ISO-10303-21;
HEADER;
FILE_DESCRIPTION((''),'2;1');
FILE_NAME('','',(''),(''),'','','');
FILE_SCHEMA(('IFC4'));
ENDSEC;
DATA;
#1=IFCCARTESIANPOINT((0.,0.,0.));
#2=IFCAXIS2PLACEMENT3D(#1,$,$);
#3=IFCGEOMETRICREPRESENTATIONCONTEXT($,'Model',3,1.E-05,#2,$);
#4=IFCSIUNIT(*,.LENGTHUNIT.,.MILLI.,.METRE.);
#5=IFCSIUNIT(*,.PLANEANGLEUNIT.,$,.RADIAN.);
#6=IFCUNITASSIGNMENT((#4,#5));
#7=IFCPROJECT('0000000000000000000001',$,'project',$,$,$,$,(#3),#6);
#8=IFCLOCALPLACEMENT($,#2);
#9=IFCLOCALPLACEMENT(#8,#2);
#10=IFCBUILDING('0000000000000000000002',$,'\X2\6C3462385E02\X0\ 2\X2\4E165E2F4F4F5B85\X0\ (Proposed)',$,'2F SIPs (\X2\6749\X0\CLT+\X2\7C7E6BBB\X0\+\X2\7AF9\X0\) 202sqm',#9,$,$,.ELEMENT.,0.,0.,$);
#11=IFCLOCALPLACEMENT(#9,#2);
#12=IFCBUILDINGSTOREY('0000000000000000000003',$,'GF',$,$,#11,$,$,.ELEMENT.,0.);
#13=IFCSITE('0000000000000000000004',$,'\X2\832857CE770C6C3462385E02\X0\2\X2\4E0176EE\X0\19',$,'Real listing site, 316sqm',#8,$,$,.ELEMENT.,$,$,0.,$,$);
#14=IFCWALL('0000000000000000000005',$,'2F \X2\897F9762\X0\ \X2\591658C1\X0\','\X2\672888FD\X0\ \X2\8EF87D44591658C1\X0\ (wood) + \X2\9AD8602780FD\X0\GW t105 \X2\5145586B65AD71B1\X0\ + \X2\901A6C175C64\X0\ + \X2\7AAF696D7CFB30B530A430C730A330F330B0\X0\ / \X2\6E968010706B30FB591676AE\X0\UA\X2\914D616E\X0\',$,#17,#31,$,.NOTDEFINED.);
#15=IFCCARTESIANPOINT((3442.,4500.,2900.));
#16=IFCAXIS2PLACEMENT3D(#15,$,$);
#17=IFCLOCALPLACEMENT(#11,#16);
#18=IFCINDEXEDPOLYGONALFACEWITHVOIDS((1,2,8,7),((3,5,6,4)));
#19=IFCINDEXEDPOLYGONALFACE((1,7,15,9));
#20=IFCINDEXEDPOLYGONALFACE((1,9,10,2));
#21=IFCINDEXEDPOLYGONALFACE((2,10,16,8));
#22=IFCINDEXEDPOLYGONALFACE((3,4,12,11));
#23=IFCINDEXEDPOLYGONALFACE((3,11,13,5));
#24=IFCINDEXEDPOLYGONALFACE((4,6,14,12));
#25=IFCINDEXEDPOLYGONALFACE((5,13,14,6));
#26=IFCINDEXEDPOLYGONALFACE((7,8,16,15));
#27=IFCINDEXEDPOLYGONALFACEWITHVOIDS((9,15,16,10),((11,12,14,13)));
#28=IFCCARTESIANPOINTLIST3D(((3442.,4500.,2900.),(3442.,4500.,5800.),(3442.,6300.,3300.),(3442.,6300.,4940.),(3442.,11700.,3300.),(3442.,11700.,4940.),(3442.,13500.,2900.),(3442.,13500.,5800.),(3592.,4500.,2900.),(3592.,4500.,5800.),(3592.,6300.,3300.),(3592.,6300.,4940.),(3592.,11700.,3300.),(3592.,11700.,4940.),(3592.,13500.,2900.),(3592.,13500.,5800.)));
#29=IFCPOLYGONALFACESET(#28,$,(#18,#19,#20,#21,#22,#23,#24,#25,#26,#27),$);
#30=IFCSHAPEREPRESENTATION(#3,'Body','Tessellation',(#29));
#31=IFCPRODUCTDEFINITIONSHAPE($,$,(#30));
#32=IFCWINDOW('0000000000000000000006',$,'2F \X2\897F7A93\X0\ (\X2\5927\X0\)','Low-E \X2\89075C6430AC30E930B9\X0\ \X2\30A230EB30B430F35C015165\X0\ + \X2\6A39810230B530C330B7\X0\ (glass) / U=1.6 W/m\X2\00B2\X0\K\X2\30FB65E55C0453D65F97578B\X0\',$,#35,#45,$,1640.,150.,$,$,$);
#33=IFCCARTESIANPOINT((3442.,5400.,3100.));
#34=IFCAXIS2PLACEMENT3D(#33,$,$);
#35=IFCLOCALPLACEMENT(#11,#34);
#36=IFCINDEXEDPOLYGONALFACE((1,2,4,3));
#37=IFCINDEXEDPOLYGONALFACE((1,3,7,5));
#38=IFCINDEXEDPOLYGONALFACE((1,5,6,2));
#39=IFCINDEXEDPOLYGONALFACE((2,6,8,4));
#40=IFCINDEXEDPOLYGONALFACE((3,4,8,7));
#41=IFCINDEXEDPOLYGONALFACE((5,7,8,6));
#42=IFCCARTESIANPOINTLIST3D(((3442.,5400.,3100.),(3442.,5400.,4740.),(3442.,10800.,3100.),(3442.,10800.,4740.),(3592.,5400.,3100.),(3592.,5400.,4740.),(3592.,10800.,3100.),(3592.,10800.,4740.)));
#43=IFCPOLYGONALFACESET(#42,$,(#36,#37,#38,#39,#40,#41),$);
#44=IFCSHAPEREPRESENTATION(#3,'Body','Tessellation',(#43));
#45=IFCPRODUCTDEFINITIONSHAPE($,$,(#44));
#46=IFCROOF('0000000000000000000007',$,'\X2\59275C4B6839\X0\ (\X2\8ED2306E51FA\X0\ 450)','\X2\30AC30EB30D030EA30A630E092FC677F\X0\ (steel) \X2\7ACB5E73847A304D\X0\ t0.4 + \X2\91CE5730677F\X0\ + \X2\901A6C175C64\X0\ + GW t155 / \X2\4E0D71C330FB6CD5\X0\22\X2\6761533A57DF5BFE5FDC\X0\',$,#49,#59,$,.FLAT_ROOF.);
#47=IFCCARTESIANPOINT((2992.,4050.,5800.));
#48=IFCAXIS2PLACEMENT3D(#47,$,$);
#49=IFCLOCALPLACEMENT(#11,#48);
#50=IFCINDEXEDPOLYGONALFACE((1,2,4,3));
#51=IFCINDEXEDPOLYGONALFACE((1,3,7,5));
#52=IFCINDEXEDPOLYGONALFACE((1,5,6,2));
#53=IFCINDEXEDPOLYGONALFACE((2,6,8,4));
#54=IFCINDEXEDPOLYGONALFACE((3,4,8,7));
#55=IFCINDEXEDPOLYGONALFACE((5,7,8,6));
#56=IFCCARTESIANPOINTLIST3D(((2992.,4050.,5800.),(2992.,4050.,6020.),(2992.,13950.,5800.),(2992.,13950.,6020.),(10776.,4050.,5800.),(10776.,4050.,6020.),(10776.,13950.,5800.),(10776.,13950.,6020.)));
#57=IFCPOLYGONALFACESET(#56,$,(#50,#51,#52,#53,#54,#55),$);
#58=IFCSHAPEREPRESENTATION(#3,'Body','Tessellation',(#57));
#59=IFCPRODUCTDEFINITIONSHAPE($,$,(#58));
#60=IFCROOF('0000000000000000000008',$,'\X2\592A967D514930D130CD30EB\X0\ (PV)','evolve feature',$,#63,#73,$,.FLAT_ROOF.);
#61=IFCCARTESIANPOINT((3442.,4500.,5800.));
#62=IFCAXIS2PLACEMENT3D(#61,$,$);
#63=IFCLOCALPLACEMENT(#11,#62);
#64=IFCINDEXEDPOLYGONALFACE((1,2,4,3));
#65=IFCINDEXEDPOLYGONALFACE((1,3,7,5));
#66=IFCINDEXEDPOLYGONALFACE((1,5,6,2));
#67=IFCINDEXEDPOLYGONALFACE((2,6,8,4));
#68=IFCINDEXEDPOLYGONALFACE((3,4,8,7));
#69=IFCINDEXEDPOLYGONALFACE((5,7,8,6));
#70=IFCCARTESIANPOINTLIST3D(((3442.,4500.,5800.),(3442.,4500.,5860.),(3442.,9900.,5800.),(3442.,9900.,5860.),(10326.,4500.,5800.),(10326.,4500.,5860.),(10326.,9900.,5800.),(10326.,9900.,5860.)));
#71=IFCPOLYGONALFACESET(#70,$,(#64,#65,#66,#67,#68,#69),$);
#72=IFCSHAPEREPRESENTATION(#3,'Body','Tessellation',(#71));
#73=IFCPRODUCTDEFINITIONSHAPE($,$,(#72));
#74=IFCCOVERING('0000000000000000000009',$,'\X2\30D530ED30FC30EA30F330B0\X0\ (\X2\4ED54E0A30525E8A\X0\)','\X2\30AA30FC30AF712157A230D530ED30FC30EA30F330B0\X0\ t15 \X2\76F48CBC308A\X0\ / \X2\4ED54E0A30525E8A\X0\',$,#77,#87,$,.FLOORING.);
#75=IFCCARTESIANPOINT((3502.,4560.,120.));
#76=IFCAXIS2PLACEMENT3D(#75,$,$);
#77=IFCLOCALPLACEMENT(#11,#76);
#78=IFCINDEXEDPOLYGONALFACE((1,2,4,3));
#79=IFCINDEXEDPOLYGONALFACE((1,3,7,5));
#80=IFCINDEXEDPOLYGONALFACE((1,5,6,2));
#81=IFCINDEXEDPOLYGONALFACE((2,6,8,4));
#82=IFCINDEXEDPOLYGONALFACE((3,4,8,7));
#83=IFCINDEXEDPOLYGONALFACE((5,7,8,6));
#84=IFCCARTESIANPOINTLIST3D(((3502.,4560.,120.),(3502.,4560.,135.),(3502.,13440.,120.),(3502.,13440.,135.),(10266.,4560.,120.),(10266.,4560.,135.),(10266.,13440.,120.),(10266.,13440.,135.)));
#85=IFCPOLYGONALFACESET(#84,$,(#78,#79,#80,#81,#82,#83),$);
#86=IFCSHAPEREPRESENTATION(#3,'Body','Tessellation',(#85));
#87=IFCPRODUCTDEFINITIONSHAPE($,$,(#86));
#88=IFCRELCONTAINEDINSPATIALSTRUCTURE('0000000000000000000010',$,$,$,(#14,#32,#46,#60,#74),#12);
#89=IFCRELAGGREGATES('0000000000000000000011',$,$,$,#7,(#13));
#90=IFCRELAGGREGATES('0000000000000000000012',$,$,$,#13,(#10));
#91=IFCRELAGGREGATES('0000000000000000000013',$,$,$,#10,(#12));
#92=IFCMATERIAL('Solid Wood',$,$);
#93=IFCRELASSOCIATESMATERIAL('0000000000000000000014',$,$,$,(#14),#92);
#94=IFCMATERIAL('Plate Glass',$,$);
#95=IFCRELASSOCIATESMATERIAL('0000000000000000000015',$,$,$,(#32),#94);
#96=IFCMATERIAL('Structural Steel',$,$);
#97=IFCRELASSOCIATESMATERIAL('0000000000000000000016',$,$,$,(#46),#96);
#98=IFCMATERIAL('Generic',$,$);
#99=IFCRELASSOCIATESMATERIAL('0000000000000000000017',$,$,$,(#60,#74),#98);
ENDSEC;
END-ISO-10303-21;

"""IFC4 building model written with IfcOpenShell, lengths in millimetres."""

from ifc_helpers import new_model, si_unit, frame, frame_2d, origin, place, context, project, spatial, rectangle, extrude, material, element, fill, save


model = new_model("IFC4")

# Units and contexts
model_context = context("Model", 3, precision=1e-05, world=origin())
ifc_project = project(units=[si_unit("LENGTHUNIT", "METRE", prefix="MILLI"), si_unit("PLANEANGLEUNIT", "RADIAN")], contexts=[model_context])

# Site, building, storey
site_placement = place(None, origin())
site = spatial("IfcSite", under=ifc_project, at=site_placement, Name="茨城県水戸市2丁目19", ObjectType="Real listing site, 316sqm", CompositionType="ELEMENT", RefElevation=0.0)
building_placement = place(site_placement, origin())
building = spatial("IfcBuilding", under=site, at=building_placement, Name="水戸市 2世帯住宅 (Proposed)", ObjectType="2F SIPs (杉CLT+籾殻+竹) 202sqm", CompositionType="ELEMENT", ElevationOfRefHeight=0.0, ElevationOfTerrain=0.0)
storey_placement = place(building_placement, origin())
storey = spatial("IfcBuildingStorey", under=building, at=storey_placement, Name="GF", CompositionType="ELEMENT", Elevation=0.0)

# Shared definitions
ifc_material_1 = material(Name="Solid Wood")

# Shared definitions
ifc_material_2 = material(Name="Plate Glass")
ifc_material_3 = material(Name="Generic")

# Wall, opening, window
wall_1_placement = place(storey_placement, frame((3442.0, 4500.0, 2900.0)))
wall_1 = element("IfcWall", 1, at=wall_1_placement, inside=storey, material=ifc_material_1, Name="2F 西面 外壁", Description="木製 軸組外壁 (wood) + 高性能GW t105 充填断熱 + 通気層 + 窯業系サイディング / 準耐火・外皮UA配慮", PredefinedType="NOTDEFINED", context=model_context, shape_type="SweptSolid", body=[
    extrude(rectangle(XDim=150.0, YDim=9000.0, at=frame_2d((75.0, 4500.0))), frame((3442.0, 4500.0, 2900.0)), (0.0, 0.0, 1.0), 2900.0),
])
opening_1_placement = place(storey_placement, frame((3442.0, 5400.0, 3100.0)))
opening_1 = element("IfcOpeningElement", 2, at=opening_1_placement, cuts=wall_1, PredefinedType="NOTDEFINED", context=model_context, shape_type="SweptSolid", body=[
    extrude(rectangle(XDim=150.0, YDim=5400.0, at=frame_2d((75.0, 2700.0))), frame((3442.0, 5400.0, 3100.0)), (0.0, 0.0, 1.0), 1640.0),
])
window_1_placement = place(storey_placement, frame((3442.0, 5400.0, 3100.0)))
window_1 = element("IfcWindow", 3, at=window_1_placement, inside=storey, material=ifc_material_2, Name="2F 西窓 (大)", Description="Low-E 複層ガラス アルゴン封入 + 樹脂サッシ (glass) / U=1.6 W/m²K・日射取得型", OverallHeight=1640.0, OverallWidth=150.0, context=model_context, shape_type="SweptSolid", body=[
    extrude(rectangle(XDim=150.0, YDim=5400.0, at=frame_2d((75.0, 2700.0))), frame((3442.0, 5400.0, 3100.0)), (0.0, 0.0, 1.0), 1640.0),
])
fill(opening_1, window_1)

# Roofs
ifc_material_4 = material(Name="Structural Steel")
roof_1_placement = place(storey_placement, frame((2992.0, 4050.0, 5800.0)))
element("IfcRoof", 4, at=roof_1_placement, inside=storey, material=ifc_material_4, Name="大屋根 (軒の出 450)", Description="ガルバリウム鋼板 (steel) 立平葺き t0.4 + 野地板 + 通気層 + GW t155 / 不燃・法22条区域対応", PredefinedType="FLAT_ROOF", context=model_context, shape_type="SweptSolid", body=[
    extrude(rectangle(XDim=7784.0, YDim=9900.0, at=frame_2d((3892.0, 4950.0))), frame((2992.0, 4050.0, 5800.0)), (0.0, 0.0, 1.0), 220.0),
])
roof_2_placement = place(storey_placement, frame((3442.0, 4500.0, 5800.0)))
element("IfcRoof", 5, at=roof_2_placement, inside=storey, material=ifc_material_3, Name="太陽光パネル (PV)", Description="evolve feature", PredefinedType="FLAT_ROOF", context=model_context, shape_type="SweptSolid", body=[
    extrude(rectangle(XDim=6884.0, YDim=5400.0, at=frame_2d((3442.0, 2700.0))), frame((3442.0, 4500.0, 5800.0)), (0.0, 0.0, 1.0), 60.0),
])

# Covering
covering_placement = place(storey_placement, frame((3502.0, 4560.0, 120.0)))
element("IfcCovering", 6, at=covering_placement, inside=storey, material=ifc_material_3, Name="フローリング (仕上げ床)", Description="オーク無垢フローリング t15 直貼り / 仕上げ床", PredefinedType="FLOORING", context=model_context, shape_type="SweptSolid", body=[
    extrude(rectangle(XDim=6764.0, YDim=8880.0, at=frame_2d((3382.0, 4440.0))), frame((3502.0, 4560.0, 120.0)), (0.0, 0.0, 1.0), 15.0),
])

save(model, "model.ifc")
